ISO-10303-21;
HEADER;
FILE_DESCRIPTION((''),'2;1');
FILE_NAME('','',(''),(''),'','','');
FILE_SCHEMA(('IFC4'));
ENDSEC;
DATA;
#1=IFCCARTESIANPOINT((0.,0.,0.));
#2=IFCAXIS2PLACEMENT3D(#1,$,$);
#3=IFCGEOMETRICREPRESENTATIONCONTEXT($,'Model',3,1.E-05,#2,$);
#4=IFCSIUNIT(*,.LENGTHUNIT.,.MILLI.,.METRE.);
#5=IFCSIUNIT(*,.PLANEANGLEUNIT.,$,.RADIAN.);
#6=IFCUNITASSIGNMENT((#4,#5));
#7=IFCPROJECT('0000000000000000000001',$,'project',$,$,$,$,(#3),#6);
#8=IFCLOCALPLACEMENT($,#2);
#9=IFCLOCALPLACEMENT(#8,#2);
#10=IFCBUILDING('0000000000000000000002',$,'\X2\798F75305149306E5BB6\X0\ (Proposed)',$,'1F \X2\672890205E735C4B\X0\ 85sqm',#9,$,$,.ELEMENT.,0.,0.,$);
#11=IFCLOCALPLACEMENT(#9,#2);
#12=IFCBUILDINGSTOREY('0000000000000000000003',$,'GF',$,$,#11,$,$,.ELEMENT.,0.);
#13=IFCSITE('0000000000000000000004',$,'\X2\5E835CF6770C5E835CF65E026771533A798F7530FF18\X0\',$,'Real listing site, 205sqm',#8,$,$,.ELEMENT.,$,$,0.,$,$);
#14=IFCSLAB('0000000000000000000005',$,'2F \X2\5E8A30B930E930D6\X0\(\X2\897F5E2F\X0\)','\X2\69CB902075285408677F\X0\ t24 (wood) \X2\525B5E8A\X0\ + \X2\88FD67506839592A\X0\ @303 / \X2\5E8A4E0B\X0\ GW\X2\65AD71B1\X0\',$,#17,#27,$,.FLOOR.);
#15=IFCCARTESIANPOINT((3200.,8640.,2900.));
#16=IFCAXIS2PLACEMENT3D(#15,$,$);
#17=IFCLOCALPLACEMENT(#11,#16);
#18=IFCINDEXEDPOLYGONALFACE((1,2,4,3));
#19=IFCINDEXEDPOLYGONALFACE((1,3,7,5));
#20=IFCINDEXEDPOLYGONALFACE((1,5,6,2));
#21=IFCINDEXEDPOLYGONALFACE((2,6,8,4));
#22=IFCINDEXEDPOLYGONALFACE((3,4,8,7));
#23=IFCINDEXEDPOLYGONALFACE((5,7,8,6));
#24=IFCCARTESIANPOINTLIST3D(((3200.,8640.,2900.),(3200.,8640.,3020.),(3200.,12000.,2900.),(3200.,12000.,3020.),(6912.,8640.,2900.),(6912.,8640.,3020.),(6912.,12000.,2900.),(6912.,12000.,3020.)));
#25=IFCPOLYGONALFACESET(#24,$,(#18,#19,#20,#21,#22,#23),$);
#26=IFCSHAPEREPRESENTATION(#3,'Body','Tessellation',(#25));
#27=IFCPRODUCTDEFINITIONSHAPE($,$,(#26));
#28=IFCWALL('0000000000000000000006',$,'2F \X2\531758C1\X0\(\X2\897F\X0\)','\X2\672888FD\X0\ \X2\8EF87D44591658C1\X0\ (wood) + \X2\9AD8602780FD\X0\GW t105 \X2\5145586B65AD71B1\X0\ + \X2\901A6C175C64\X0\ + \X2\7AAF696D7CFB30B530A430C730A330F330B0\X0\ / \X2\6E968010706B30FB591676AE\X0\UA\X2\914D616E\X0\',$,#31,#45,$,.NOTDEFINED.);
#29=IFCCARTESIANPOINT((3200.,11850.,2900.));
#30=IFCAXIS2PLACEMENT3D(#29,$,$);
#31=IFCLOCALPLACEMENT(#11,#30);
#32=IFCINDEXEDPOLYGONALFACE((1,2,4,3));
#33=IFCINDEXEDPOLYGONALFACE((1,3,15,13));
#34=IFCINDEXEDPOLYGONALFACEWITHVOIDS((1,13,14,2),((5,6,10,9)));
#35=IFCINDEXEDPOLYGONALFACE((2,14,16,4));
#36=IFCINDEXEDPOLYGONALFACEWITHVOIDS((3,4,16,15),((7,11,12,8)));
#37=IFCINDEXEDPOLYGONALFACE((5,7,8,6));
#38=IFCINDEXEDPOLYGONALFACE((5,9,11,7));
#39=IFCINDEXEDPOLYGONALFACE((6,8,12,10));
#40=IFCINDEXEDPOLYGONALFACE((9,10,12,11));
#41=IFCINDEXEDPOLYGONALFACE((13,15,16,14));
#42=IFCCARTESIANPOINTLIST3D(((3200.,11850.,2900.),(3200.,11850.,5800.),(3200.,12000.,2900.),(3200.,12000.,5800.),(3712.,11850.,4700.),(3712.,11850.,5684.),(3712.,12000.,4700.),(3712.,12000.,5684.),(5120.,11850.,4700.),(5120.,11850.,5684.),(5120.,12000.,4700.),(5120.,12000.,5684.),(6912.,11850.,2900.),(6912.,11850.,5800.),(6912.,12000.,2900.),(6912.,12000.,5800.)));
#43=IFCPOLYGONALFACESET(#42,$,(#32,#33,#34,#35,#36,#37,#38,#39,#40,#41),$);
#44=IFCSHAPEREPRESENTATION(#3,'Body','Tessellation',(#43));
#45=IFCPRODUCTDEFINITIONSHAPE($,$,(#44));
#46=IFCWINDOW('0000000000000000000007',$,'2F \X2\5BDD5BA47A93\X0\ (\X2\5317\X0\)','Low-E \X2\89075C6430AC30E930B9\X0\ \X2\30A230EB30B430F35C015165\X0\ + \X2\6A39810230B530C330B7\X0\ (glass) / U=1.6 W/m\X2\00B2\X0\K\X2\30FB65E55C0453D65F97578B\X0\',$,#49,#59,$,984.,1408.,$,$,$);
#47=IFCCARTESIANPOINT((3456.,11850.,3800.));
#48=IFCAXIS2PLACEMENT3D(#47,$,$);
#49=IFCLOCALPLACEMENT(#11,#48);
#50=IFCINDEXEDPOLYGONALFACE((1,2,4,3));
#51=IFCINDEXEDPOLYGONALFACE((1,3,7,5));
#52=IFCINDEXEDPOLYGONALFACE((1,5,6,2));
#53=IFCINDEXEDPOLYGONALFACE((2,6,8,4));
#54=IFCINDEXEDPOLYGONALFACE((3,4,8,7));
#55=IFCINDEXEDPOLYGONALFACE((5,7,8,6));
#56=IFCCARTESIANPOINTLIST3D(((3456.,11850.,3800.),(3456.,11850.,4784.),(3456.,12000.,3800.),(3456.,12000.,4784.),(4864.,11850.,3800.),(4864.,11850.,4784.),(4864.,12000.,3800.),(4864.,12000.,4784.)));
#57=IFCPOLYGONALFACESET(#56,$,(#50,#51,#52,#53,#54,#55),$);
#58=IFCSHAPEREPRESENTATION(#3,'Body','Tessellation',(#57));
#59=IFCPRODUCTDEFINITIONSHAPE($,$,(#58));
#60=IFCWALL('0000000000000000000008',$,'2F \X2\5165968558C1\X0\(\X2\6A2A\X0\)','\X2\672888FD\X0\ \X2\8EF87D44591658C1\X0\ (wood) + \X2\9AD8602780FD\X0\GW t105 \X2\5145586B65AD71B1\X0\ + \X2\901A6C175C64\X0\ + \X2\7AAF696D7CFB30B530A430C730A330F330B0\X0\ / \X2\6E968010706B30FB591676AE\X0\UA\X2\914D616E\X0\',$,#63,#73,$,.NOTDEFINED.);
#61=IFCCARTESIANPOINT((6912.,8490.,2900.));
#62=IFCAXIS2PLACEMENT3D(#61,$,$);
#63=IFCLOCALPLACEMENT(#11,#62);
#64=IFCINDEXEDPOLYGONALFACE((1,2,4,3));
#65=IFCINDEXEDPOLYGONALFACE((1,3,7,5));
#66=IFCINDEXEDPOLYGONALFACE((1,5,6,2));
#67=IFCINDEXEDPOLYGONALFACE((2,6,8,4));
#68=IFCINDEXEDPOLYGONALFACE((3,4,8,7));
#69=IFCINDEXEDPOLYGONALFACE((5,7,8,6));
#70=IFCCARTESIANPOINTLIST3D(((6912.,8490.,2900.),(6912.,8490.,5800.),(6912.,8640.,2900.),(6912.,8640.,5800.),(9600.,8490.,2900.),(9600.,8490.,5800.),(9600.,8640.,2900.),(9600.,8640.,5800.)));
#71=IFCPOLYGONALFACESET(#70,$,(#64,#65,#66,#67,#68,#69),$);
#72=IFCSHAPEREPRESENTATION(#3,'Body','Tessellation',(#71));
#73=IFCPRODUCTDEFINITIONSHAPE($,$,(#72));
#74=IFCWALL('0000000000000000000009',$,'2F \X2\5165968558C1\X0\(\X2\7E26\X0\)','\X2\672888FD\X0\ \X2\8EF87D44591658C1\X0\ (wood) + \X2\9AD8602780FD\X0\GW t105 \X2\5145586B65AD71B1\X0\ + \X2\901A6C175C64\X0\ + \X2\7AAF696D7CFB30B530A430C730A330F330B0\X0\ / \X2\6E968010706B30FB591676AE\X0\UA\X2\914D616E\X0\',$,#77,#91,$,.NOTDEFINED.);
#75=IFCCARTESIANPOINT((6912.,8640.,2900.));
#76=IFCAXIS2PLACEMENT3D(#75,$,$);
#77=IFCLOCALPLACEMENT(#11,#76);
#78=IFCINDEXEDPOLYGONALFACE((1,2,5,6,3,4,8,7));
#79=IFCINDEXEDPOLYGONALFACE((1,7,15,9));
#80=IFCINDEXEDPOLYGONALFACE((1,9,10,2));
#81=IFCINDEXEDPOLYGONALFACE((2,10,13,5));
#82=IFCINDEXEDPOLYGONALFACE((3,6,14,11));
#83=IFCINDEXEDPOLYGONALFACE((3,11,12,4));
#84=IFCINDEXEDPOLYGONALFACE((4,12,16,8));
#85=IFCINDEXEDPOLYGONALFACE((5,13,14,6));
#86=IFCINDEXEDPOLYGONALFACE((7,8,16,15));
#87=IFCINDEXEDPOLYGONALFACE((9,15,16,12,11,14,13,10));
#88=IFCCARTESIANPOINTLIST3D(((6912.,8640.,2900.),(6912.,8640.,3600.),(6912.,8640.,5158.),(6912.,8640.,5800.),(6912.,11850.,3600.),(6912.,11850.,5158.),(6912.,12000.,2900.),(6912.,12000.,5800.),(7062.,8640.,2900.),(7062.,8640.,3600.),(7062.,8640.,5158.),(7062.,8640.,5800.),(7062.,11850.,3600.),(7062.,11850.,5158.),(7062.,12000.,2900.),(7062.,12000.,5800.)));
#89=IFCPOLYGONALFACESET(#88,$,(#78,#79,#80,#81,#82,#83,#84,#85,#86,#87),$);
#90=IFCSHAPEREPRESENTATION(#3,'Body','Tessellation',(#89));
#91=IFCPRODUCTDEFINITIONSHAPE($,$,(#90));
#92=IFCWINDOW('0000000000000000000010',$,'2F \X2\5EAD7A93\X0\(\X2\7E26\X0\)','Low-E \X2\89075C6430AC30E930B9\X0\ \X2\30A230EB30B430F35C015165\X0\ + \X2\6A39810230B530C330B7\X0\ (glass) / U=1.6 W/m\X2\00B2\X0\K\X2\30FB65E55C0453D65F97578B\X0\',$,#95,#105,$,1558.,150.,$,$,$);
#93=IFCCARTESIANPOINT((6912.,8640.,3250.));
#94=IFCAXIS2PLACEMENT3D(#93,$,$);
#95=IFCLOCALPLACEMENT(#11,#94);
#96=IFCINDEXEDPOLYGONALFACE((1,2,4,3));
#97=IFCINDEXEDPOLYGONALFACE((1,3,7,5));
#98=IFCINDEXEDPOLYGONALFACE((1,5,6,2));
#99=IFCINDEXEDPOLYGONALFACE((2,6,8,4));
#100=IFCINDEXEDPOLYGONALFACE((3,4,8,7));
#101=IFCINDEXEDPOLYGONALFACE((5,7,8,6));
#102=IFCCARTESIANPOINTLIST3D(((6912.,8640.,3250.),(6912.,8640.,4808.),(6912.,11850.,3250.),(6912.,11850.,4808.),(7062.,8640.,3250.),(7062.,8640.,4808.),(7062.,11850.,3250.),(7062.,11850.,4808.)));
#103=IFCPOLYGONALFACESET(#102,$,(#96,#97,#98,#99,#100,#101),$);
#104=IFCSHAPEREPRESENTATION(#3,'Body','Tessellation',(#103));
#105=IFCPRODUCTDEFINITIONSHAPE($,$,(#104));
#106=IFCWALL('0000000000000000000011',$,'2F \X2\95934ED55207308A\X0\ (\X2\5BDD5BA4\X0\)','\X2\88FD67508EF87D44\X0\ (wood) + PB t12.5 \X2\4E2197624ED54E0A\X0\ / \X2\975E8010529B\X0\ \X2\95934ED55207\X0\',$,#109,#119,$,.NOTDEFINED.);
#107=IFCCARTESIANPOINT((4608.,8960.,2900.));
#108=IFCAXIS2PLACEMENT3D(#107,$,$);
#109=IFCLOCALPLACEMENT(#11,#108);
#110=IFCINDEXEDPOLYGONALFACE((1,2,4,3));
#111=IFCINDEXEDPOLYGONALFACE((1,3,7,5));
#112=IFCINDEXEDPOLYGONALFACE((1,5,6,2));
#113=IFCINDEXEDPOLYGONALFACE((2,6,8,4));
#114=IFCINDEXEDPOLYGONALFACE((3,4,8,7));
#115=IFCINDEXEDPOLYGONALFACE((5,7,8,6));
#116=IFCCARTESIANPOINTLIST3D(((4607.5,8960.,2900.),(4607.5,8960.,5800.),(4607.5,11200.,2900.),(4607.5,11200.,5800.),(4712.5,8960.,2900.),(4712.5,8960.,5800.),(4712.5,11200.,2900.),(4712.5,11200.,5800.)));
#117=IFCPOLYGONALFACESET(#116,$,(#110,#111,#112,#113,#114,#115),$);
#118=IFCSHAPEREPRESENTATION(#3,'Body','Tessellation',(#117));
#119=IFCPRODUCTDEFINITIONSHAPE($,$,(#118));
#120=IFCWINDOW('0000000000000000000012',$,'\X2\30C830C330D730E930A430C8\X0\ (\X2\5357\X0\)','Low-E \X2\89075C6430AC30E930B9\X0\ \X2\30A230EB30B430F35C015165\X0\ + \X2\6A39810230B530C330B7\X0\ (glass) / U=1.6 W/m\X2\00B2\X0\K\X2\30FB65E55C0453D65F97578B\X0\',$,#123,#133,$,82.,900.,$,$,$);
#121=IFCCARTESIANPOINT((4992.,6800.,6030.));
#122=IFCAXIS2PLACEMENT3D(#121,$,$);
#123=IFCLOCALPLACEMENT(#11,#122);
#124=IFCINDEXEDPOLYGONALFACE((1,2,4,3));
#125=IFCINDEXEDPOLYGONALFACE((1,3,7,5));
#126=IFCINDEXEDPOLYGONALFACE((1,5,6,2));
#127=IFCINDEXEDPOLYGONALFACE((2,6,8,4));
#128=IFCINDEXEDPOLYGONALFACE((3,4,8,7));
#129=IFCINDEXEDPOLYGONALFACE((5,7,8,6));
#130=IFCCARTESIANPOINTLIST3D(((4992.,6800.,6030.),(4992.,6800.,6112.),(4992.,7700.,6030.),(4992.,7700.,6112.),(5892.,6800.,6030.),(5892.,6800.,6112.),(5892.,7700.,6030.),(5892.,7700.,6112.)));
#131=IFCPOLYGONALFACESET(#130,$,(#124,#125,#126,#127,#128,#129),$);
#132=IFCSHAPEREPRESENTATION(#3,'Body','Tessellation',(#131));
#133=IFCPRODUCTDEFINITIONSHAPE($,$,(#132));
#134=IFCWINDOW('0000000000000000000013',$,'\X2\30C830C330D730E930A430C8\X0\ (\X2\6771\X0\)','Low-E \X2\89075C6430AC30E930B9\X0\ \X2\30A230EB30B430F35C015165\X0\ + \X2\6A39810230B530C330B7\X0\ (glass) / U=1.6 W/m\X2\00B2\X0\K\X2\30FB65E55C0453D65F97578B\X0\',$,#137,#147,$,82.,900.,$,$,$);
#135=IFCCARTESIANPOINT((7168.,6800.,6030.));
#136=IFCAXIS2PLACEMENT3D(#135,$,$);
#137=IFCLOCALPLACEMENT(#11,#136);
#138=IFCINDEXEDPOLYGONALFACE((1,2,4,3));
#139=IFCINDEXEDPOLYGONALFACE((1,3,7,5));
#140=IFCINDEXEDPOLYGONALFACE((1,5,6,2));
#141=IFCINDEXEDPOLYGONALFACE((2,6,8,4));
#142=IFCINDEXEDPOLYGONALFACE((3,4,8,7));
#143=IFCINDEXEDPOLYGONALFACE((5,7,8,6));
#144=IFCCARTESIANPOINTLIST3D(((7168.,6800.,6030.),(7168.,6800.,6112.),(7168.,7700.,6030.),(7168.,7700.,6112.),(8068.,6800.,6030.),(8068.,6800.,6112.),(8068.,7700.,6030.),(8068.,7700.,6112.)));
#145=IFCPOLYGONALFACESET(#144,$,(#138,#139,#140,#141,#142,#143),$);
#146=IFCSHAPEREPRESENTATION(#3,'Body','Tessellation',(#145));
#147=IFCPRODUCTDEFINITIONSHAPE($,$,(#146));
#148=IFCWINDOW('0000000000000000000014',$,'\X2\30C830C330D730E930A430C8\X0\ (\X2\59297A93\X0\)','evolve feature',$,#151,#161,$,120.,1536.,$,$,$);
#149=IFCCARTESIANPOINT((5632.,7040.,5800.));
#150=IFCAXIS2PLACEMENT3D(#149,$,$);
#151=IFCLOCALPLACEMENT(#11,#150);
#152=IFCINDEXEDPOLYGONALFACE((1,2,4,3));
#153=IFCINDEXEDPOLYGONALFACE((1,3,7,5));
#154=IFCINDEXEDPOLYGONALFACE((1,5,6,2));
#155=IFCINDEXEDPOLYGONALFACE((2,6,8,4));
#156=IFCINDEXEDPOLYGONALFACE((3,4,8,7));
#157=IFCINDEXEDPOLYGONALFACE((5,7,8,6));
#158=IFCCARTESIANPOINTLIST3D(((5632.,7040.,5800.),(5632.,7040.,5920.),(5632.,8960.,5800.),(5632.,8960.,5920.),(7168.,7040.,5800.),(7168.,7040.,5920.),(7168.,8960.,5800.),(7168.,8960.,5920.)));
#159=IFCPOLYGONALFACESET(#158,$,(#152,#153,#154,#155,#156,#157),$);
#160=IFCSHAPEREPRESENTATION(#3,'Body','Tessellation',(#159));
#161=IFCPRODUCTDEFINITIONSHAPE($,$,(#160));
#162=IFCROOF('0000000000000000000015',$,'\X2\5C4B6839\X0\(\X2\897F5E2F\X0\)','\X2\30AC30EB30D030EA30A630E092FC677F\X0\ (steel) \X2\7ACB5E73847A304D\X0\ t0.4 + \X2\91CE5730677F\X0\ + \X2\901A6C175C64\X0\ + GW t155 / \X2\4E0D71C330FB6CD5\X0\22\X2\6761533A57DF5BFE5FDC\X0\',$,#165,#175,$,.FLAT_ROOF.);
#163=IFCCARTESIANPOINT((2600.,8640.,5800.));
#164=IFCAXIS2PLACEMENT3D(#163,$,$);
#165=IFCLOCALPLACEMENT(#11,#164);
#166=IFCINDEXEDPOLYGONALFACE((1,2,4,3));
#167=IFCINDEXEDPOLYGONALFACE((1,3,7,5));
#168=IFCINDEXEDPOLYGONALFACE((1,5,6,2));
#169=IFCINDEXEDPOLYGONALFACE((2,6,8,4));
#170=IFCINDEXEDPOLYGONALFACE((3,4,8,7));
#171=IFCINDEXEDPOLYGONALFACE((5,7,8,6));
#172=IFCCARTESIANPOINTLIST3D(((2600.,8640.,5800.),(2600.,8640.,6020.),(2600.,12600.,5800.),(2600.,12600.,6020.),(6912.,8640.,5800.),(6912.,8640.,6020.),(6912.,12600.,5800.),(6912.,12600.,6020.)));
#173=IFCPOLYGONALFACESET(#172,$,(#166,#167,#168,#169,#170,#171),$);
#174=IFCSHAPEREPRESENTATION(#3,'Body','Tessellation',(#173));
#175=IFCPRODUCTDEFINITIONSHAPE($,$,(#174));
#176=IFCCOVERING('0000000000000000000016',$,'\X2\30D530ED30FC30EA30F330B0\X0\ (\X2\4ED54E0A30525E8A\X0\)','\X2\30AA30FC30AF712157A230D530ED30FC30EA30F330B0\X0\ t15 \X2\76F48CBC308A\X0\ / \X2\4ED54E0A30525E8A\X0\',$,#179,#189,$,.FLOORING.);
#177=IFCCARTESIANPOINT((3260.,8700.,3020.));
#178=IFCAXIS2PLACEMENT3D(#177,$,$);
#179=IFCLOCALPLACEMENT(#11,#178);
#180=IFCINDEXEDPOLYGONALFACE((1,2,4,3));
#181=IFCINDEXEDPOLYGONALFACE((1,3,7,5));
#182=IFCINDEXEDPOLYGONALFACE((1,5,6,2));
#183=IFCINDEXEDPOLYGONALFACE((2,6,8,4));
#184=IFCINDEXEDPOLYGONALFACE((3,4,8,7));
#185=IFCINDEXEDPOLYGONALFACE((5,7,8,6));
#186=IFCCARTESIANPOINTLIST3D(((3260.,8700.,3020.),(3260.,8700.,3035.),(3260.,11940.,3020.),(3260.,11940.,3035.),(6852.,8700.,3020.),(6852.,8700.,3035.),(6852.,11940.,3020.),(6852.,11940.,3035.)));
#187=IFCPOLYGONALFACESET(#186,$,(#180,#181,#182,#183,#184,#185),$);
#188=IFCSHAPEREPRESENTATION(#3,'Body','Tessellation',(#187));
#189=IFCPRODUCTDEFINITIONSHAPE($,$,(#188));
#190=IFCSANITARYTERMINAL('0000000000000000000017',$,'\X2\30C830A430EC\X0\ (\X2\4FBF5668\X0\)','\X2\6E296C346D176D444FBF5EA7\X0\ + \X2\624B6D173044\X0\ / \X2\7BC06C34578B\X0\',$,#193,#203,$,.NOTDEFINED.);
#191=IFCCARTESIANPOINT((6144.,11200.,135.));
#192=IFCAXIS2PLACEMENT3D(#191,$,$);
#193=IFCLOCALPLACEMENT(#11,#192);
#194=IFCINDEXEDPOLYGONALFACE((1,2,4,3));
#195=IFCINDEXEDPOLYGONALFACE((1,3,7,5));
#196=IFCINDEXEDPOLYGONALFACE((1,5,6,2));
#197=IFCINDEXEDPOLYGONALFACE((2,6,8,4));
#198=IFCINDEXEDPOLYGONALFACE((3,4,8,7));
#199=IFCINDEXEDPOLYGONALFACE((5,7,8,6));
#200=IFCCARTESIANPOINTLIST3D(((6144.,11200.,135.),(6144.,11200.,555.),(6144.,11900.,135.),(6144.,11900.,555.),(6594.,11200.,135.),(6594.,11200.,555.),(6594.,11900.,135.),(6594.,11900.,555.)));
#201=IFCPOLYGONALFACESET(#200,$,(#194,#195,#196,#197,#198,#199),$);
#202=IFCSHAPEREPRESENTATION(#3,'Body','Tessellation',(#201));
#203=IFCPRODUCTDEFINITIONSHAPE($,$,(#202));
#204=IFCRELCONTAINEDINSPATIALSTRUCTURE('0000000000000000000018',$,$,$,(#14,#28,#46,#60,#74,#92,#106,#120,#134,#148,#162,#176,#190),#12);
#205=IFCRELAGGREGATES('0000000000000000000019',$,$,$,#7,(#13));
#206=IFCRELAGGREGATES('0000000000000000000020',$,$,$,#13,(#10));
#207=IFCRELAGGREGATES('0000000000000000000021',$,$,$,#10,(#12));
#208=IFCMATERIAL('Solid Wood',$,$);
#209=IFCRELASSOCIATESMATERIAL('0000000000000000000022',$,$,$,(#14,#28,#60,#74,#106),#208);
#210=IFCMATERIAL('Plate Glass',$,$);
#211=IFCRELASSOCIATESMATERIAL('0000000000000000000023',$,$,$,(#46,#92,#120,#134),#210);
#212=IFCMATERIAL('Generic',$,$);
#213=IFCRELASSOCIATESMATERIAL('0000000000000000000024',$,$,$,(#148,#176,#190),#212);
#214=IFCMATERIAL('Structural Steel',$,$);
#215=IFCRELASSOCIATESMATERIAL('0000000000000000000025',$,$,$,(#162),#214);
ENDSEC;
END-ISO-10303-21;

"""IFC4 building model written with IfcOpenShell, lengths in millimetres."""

from ifc_helpers import new_model, si_unit, frame, frame_2d, origin, place, context, project, spatial, rectangle, extrude, material, element, fill, save


model = new_model("IFC4")

# Units and contexts
model_context = context("Model", 3, precision=1e-05, world=origin())
ifc_project = project(units=[si_unit("LENGTHUNIT", "METRE", prefix="MILLI"), si_unit("PLANEANGLEUNIT", "RADIAN")], contexts=[model_context])

# Site, building, storey
site_placement = place(None, origin())
site = spatial("IfcSite", under=ifc_project, at=site_placement, Name="広島県広島市東区福田８", ObjectType="Real listing site, 205sqm", CompositionType="ELEMENT", RefElevation=0.0)
building_placement = place(site_placement, origin())
building = spatial("IfcBuilding", under=site, at=building_placement, Name="福田光の家 (Proposed)", ObjectType="1F 木造平屋 85sqm", CompositionType="ELEMENT", ElevationOfRefHeight=0.0, ElevationOfTerrain=0.0)
storey_placement = place(building_placement, origin())
storey = spatial("IfcBuildingStorey", under=building, at=storey_placement, Name="GF", CompositionType="ELEMENT", Elevation=0.0)

# Slab
ifc_material_1 = material(Name="Solid Wood")
slab_placement = place(storey_placement, frame((3200.0, 8640.0, 2900.0)))
element("IfcSlab", 1, at=slab_placement, inside=storey, material=ifc_material_1, Name="2F 床スラブ(西帯)", Description="構造用合板 t24 (wood) 剛床 + 製材根太 @303 / 床下 GW断熱", PredefinedType="FLOOR", context=model_context, shape_type="SweptSolid", body=[
    extrude(rectangle(XDim=3712.0, YDim=3360.0, at=frame_2d((1856.0, 1680.0))), frame((3200.0, 8640.0, 2900.0)), (0.0, 0.0, 1.0), 120.0),
])

# Wall, opening, window
wall_1_placement = place(storey_placement, frame((3200.0, 11850.0, 2900.0)))
wall_1 = element("IfcWall", 2, at=wall_1_placement, inside=storey, material=ifc_material_1, Name="2F 北壁(西)", Description="木製 軸組外壁 (wood) + 高性能GW t105 充填断熱 + 通気層 + 窯業系サイディング / 準耐火・外皮UA配慮", PredefinedType="NOTDEFINED", context=model_context, shape_type="SweptSolid", body=[
    extrude(rectangle(XDim=3712.0, YDim=150.0, at=frame_2d((1856.0, 75.0))), frame((3200.0, 11850.0, 2900.0)), (0.0, 0.0, 1.0), 2900.0),
])
opening_1_placement = place(storey_placement, frame((3456.0, 11850.0, 3800.0)))
opening_1 = element("IfcOpeningElement", 3, at=opening_1_placement, cuts=wall_1, PredefinedType="NOTDEFINED", context=model_context, shape_type="SweptSolid", body=[
    extrude(rectangle(XDim=1408.0, YDim=150.0, at=frame_2d((704.0, 75.0))), frame((3456.0, 11850.0, 3800.0)), (0.0, 0.0, 1.0), 984.0),
])
ifc_material_2 = material(Name="Plate Glass")
window_1_placement = place(storey_placement, frame((3456.0, 11850.0, 3800.0)))
window_1 = element("IfcWindow", 4, at=window_1_placement, inside=storey, material=ifc_material_2, Name="2F 寝室窓 (北)", Description="Low-E 複層ガラス アルゴン封入 + 樹脂サッシ (glass) / U=1.6 W/m²K・日射取得型", OverallHeight=984.0, OverallWidth=1408.0, context=model_context, shape_type="SweptSolid", body=[
    extrude(rectangle(XDim=1408.0, YDim=150.0, at=frame_2d((704.0, 75.0))), frame((3456.0, 11850.0, 3800.0)), (0.0, 0.0, 1.0), 984.0),
])
fill(opening_1, window_1)

# Wall
wall_2_placement = place(storey_placement, frame((6912.0, 8490.0, 2900.0)))
element("IfcWall", 5, at=wall_2_placement, inside=storey, material=ifc_material_1, Name="2F 入隅壁(横)", Description="木製 軸組外壁 (wood) + 高性能GW t105 充填断熱 + 通気層 + 窯業系サイディング / 準耐火・外皮UA配慮", PredefinedType="NOTDEFINED", context=model_context, shape_type="SweptSolid", body=[
    extrude(rectangle(XDim=2688.0, YDim=150.0, at=frame_2d((1344.0, 75.0))), frame((6912.0, 8490.0, 2900.0)), (0.0, 0.0, 1.0), 2900.0),
])

# Wall, opening, window
wall_3_placement = place(storey_placement, frame((6912.0, 8640.0, 2900.0)))
wall_3 = element("IfcWall", 6, at=wall_3_placement, inside=storey, material=ifc_material_1, Name="2F 入隅壁(縦)", Description="木製 軸組外壁 (wood) + 高性能GW t105 充填断熱 + 通気層 + 窯業系サイディング / 準耐火・外皮UA配慮", PredefinedType="NOTDEFINED", context=model_context, shape_type="SweptSolid", body=[
    extrude(rectangle(XDim=150.0, YDim=3360.0, at=frame_2d((75.0, 1680.0))), frame((6912.0, 8640.0, 2900.0)), (0.0, 0.0, 1.0), 2900.0),
])
opening_2_placement = place(storey_placement, frame((6912.0, 8640.0, 3250.0)))
opening_2 = element("IfcOpeningElement", 7, at=opening_2_placement, cuts=wall_3, PredefinedType="NOTDEFINED", context=model_context, shape_type="SweptSolid", body=[
    extrude(rectangle(XDim=150.0, YDim=3210.0, at=frame_2d((75.0, 1605.0))), frame((6912.0, 8640.0, 3250.0)), (0.0, 0.0, 1.0), 1558.0),
])
window_2_placement = place(storey_placement, frame((6912.0, 8640.0, 3250.0)))
window_2 = element("IfcWindow", 8, at=window_2_placement, inside=storey, material=ifc_material_2, Name="2F 庭窓(縦)", Description="Low-E 複層ガラス アルゴン封入 + 樹脂サッシ (glass) / U=1.6 W/m²K・日射取得型", OverallHeight=1558.0, OverallWidth=150.0, context=model_context, shape_type="SweptSolid", body=[
    extrude(rectangle(XDim=150.0, YDim=3210.0, at=frame_2d((75.0, 1605.0))), frame((6912.0, 8640.0, 3250.0)), (0.0, 0.0, 1.0), 1558.0),
])
fill(opening_2, window_2)

# Wall
wall_4_placement = place(storey_placement, frame((4608.0, 8960.0, 2900.0)))
element("IfcWall", 9, at=wall_4_placement, inside=storey, material=ifc_material_1, Name="2F 間仕切り (寝室)", Description="製材軸組 (wood) + PB t12.5 両面仕上 / 非耐力 間仕切", PredefinedType="NOTDEFINED", context=model_context, shape_type="SweptSolid", body=[
    extrude(rectangle(XDim=105.0, YDim=2240.0, at=frame_2d((52.0, 1120.0))), frame((4608.0, 8960.0, 2900.0)), (0.0, 0.0, 1.0), 2900.0),
])

# Windows
window_3_placement = place(storey_placement, frame((4992.0, 6800.0, 6030.0)))
element("IfcWindow", 10, at=window_3_placement, inside=storey, material=ifc_material_2, Name="トップライト (南)", Description="Low-E 複層ガラス アルゴン封入 + 樹脂サッシ (glass) / U=1.6 W/m²K・日射取得型", OverallHeight=82.0, OverallWidth=900.0, context=model_context, shape_type="SweptSolid", body=[
    extrude(rectangle(XDim=900.0, YDim=900.0, at=frame_2d((450.0, 450.0))), frame((4992.0, 6800.0, 6030.0)), (0.0, 0.0, 1.0), 82.0),
])
window_4_placement = place(storey_placement, frame((7168.0, 6800.0, 6030.0)))
element("IfcWindow", 11, at=window_4_placement, inside=storey, material=ifc_material_2, Name="トップライト (東)", Description="Low-E 複層ガラス アルゴン封入 + 樹脂サッシ (glass) / U=1.6 W/m²K・日射取得型", OverallHeight=82.0, OverallWidth=900.0, context=model_context, shape_type="SweptSolid", body=[
    extrude(rectangle(XDim=900.0, YDim=900.0, at=frame_2d((450.0, 450.0))), frame((7168.0, 6800.0, 6030.0)), (0.0, 0.0, 1.0), 82.0),
])
ifc_material_3 = material(Name="Generic")
window_5_placement = place(storey_placement, frame((5632.0, 7040.0, 5800.0)))
element("IfcWindow", 12, at=window_5_placement, inside=storey, material=ifc_material_3, Name="トップライト (天窓)", Description="evolve feature", OverallHeight=120.0, OverallWidth=1536.0, context=model_context, shape_type="SweptSolid", body=[
    extrude(rectangle(XDim=1536.0, YDim=1920.0, at=frame_2d((768.0, 960.0))), frame((5632.0, 7040.0, 5800.0)), (0.0, 0.0, 1.0), 120.0),
])

# Roof
ifc_material_4 = material(Name="Structural Steel")
for number, where, name in (
    (13, (2600.0, 8640.0, 5800.0), "屋根(西帯)"),
):
    element("IfcRoof", number, at=place(storey_placement, frame(where)), inside=storey, material=ifc_material_4, Name=name, Description="ガルバリウム鋼板 (steel) 立平葺き t0.4 + 野地板 + 通気層 + GW t155 / 不燃・法22条区域対応", PredefinedType="FLAT_ROOF", context=model_context, shape_type="SweptSolid", body=[
        extrude(rectangle(XDim=4312.0, YDim=3960.0, at=frame_2d((2156.0, 1980.0))), frame((2600.0, 8640.0, 5800.0)), (0.0, 0.0, 1.0), 220.0),
    ])

# Covering
covering_placement = place(storey_placement, frame((3260.0, 8700.0, 3020.0)))
element("IfcCovering", 14, at=covering_placement, inside=storey, material=ifc_material_3, Name="フローリング (仕上げ床)", Description="オーク無垢フローリング t15 直貼り / 仕上げ床", PredefinedType="FLOORING", context=model_context, shape_type="SweptSolid", body=[
    extrude(rectangle(XDim=3592.0, YDim=3240.0, at=frame_2d((1796.0, 1620.0))), frame((3260.0, 8700.0, 3020.0)), (0.0, 0.0, 1.0), 15.0),
])

# Sanitary terminal
sanitary_terminal_placement = place(storey_placement, frame((6144.0, 11200.0, 135.0)))
element("IfcSanitaryTerminal", 15, at=sanitary_terminal_placement, inside=storey, material=ifc_material_3, Name="トイレ (便器)", Description="温水洗浄便座 + 手洗い / 節水型", PredefinedType="NOTDEFINED", context=model_context, shape_type="SweptSolid", body=[
    extrude(rectangle(XDim=450.0, YDim=700.0, at=frame_2d((225.0, 350.0))), frame((6144.0, 11200.0, 135.0)), (0.0, 0.0, 1.0), 420.0),
])

save(model, "model.ifc")
